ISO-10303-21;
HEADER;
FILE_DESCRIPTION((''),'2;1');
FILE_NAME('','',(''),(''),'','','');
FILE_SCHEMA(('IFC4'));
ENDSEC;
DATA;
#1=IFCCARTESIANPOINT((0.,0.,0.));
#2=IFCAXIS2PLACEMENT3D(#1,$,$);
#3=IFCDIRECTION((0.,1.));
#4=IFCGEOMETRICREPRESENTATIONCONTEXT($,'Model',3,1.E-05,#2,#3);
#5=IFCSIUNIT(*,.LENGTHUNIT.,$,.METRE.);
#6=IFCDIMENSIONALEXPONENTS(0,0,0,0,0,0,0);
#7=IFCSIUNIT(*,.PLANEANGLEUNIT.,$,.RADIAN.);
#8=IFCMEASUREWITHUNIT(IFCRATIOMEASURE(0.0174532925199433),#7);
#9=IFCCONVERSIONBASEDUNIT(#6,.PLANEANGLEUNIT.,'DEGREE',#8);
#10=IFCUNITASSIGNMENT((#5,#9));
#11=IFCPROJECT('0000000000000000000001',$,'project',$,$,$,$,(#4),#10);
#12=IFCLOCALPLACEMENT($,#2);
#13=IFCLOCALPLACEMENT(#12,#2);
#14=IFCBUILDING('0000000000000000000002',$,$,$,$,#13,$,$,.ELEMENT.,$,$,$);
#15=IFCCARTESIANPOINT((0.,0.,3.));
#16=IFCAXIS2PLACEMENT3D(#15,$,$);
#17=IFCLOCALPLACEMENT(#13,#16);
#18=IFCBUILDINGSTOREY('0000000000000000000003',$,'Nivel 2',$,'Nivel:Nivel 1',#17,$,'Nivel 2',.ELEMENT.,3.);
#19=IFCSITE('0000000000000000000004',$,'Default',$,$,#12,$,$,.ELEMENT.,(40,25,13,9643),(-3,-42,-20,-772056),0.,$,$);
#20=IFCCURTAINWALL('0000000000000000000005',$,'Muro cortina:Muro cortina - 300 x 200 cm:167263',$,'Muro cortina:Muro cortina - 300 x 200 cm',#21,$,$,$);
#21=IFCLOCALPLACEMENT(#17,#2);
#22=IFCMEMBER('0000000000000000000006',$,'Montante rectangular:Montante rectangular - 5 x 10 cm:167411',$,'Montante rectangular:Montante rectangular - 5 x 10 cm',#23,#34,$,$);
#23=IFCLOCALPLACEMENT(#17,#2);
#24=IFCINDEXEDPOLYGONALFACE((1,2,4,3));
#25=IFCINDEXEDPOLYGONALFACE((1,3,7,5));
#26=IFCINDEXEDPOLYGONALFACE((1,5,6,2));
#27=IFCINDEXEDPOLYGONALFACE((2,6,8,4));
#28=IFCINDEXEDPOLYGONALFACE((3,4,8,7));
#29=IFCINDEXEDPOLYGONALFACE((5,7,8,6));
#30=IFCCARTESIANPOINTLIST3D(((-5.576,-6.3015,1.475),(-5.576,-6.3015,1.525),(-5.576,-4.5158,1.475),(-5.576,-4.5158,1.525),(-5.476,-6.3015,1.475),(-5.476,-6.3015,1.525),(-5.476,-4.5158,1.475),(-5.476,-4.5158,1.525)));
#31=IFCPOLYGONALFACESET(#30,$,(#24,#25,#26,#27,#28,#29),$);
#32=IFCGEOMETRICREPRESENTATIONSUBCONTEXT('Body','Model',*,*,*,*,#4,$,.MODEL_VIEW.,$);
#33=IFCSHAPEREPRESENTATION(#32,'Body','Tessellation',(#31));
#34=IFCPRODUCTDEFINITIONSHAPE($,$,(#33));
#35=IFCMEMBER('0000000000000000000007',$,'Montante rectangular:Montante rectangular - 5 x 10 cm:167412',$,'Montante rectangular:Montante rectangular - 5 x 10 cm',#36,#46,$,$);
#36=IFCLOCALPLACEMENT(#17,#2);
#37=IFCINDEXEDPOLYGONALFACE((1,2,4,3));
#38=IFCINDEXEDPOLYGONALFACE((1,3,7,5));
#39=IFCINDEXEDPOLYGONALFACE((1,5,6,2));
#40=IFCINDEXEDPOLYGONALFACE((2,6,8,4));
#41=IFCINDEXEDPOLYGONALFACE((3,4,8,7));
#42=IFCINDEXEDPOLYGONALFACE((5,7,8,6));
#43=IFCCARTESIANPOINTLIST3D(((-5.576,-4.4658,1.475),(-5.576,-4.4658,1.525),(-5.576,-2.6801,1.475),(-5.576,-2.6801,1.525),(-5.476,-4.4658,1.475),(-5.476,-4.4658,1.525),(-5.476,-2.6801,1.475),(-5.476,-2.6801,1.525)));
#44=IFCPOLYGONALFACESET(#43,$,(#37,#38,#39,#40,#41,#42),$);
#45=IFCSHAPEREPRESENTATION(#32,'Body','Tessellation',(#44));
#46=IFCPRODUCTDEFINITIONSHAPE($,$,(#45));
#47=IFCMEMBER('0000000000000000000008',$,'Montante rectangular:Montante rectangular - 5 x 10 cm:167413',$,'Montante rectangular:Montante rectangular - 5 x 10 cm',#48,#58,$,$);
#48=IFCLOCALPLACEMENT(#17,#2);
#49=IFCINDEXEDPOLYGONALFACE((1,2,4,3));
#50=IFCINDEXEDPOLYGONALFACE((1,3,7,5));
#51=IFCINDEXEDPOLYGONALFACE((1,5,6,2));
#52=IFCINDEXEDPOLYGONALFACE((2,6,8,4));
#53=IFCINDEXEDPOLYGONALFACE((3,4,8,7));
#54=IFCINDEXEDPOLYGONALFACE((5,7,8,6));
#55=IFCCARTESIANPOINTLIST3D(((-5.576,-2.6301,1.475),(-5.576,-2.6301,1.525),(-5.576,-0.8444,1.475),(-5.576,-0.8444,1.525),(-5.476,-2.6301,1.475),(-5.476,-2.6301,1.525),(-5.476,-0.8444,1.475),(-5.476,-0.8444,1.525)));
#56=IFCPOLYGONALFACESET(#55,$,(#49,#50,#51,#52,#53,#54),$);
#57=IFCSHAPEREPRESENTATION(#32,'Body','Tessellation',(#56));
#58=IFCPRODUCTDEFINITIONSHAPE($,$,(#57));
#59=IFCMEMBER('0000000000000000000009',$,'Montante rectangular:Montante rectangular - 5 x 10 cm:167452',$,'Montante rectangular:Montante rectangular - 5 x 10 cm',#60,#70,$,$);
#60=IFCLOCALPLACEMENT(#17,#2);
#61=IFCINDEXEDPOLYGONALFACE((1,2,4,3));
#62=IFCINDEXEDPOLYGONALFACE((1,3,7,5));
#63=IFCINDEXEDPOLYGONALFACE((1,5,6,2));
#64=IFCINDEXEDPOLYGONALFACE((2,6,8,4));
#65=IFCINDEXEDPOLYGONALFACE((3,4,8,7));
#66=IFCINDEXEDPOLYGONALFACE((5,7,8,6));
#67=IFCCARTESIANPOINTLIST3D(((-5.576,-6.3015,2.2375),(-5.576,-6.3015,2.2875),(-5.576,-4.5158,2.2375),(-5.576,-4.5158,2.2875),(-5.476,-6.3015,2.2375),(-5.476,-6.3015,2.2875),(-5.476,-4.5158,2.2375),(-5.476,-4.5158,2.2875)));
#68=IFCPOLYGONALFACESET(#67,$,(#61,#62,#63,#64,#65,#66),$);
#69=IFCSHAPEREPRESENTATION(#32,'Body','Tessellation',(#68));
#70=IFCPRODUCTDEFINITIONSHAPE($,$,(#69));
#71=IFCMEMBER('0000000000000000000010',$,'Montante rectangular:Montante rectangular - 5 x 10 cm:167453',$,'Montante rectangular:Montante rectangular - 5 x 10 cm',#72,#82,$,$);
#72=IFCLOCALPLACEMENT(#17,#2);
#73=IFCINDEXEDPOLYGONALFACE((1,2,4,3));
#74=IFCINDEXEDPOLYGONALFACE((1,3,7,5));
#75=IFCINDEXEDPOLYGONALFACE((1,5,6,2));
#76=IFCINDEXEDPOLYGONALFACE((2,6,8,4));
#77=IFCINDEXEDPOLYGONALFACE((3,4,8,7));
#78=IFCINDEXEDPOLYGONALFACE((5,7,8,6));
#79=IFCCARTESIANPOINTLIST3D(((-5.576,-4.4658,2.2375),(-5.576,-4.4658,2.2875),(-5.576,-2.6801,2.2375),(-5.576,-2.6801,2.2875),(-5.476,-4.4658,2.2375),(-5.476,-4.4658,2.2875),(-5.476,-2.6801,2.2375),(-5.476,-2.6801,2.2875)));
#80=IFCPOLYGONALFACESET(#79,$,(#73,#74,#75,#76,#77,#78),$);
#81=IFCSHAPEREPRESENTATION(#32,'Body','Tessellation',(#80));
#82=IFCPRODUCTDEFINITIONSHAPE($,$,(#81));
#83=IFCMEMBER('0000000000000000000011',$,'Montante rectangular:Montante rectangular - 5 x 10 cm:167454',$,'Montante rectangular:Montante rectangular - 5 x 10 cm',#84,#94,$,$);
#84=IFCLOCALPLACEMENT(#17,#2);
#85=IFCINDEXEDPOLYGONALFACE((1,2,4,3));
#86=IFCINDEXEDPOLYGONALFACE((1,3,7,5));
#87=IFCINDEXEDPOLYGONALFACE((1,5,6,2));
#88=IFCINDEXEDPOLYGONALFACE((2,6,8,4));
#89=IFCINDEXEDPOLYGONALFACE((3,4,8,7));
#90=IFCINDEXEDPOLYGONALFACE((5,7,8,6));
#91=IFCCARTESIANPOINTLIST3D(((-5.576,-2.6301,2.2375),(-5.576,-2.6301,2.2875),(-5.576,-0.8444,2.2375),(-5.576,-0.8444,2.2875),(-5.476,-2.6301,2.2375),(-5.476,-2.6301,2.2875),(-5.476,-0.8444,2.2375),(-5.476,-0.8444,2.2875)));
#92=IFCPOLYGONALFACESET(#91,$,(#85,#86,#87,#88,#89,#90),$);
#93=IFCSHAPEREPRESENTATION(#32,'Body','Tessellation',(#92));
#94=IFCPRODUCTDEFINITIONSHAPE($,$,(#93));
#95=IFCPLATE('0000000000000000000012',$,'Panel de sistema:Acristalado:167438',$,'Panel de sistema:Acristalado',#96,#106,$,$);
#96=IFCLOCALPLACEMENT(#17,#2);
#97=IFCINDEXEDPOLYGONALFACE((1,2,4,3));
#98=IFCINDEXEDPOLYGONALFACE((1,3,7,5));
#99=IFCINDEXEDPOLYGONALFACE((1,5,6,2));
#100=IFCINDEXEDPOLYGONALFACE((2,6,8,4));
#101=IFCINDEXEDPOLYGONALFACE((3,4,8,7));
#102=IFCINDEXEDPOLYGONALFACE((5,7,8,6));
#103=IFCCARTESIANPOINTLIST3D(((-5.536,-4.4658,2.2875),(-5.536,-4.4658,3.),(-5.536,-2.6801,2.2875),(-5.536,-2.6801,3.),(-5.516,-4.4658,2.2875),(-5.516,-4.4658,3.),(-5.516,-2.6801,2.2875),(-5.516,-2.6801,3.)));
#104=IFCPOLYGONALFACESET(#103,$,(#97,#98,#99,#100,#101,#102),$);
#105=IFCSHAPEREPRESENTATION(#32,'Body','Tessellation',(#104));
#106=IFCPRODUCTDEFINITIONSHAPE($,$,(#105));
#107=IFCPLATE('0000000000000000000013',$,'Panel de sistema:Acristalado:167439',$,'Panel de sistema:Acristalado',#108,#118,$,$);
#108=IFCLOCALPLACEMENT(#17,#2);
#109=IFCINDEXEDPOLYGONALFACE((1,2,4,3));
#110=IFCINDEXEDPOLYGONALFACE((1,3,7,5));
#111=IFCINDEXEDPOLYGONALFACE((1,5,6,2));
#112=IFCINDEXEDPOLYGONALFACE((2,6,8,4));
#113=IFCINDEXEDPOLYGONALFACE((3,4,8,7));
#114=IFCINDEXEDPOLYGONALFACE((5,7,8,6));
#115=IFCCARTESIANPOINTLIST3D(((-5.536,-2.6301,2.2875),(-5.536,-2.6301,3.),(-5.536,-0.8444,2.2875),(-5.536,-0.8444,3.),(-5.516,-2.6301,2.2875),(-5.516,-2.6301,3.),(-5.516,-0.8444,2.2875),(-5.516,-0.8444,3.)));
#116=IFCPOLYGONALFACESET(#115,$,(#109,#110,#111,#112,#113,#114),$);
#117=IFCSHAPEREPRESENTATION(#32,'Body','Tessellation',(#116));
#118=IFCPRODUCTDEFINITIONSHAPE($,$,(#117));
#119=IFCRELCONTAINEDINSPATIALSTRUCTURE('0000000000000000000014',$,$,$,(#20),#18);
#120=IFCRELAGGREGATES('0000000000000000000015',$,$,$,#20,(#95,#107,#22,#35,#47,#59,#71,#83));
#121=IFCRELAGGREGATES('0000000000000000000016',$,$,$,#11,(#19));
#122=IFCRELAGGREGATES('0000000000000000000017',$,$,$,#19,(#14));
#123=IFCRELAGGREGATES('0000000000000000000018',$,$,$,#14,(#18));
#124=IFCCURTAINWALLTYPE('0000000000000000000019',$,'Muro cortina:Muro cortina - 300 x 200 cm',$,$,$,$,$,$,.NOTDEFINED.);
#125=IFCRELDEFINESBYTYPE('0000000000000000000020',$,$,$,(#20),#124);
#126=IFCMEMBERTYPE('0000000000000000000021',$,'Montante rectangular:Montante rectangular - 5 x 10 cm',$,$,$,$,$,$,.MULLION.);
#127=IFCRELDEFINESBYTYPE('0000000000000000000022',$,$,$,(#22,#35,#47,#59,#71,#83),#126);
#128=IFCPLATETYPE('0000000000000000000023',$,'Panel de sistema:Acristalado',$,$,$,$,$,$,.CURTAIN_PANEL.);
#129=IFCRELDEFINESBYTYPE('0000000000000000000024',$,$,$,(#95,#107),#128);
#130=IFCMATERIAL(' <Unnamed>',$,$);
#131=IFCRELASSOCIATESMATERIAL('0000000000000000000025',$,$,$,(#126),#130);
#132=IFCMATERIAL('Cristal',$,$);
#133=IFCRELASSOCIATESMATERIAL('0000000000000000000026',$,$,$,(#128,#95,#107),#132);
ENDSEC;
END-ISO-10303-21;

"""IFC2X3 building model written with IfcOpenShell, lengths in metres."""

from ifc_helpers import new_model, entity, si_unit, converted_unit, direction, frame, origin, origin_2d_with_axis, place, context, subcontext, project, spatial, rectangle, extrude, source, transform, mapped, material, type_object, type_shapes, element, aggregate, save


model = new_model("IFC2X3")

# Units and contexts
model_context = context("Model", 3, precision=1e-05, world=origin(), true_north=direction((0.0, 1.0)))
body_context = subcontext(model_context, "Body", "Model", "MODEL_VIEW")
ifc_project = project(units=[si_unit("LENGTHUNIT", "METRE"), converted_unit("PLANEANGLEUNIT", "DEGREE", entity("IfcRatioMeasure", 0.0174532925199433), si_unit("PLANEANGLEUNIT", "RADIAN"), dimensions=[0, 0, 0, 0, 0, 0, 0])], contexts=[model_context])

# Site, building, storey
site_placement = place(None, origin())
site = spatial("IfcSite", under=ifc_project, at=site_placement, Name="Default", CompositionType="ELEMENT", RefLatitude=(40, 25, 13, 9643), RefLongitude=(-3, -42, -20, -772056), RefElevation=0.0)
building_placement = place(site_placement, origin())
building = spatial("IfcBuilding", under=site, at=building_placement, CompositionType="ELEMENT")
storey_placement = place(building_placement, frame((0.0, 0.0, 3.0)))
storey = spatial("IfcBuildingStorey", under=building, at=storey_placement, Name="Nivel 2", ObjectType="Nivel:Nivel 1", LongName="Nivel 2", CompositionType="ELEMENT", Elevation=3.0)

# Curtain wall, members, plates
curtain_wall_type = type_object("IfcCurtainWallType", Name="Muro cortina:Muro cortina - 300 x 200 cm", PredefinedType="NOTDEFINED")
curtain_wall_placement = place(storey_placement, frame((0.0, 0.0, -3.0)))
curtain_wall = element("IfcCurtainWall", 1, at=curtain_wall_placement, inside=storey, type_object=curtain_wall_type, Name="Muro cortina:Muro cortina - 300 x 200 cm:167263", ObjectType="Muro cortina:Muro cortina - 300 x 200 cm")
ifc_material_1 = material(Name=" <Unnamed>")
member_type_1 = type_object("IfcMemberType", Name="Montante rectangular:Montante rectangular - 5 x 10 cm", PredefinedType="MULLION", material=ifc_material_1)
shared_shape_1 = source(origin(), body_context, "Body", "SweptSolid", [
    extrude(rectangle(XDim=0.1, YDim=0.05, at=origin_2d_with_axis()), frame((0.0, 0.0, -1.7857), z_axis=(0.0, 0.0, 1.0), x_axis=(0.0, -1.0, 0.0)), (0.0, 0.0, 1.0), 1.7857),
])
type_shapes(member_type_1, [shared_shape_1])
member_1_placement = place(storey_placement, frame((-5.526, -4.5158, 1.5), z_axis=(0.0, 1.0, 0.0), x_axis=(0.0, 0.0, 1.0)))
member_1 = element("IfcMember", 2, at=member_1_placement, type_object=member_type_1, Name="Montante rectangular:Montante rectangular - 5 x 10 cm:167411", ObjectType="Montante rectangular:Montante rectangular - 5 x 10 cm", context=body_context, shape_type="MappedRepresentation", body=[
    mapped(shared_shape_1, transform((0.0, 0.0, 0.0), scale=1.0)),
])
member_2_placement = place(storey_placement, frame((-5.526, -2.6801, 1.5), z_axis=(0.0, 1.0, 0.0), x_axis=(0.0, 0.0, 1.0)))
member_2 = element("IfcMember", 3, at=member_2_placement, type_object=member_type_1, Name="Montante rectangular:Montante rectangular - 5 x 10 cm:167412", ObjectType="Montante rectangular:Montante rectangular - 5 x 10 cm", context=body_context, shape_type="MappedRepresentation", body=[
    mapped(shared_shape_1, transform((0.0, 0.0, 0.0), scale=1.0)),
])
member_3_placement = place(storey_placement, frame((-5.526, -0.8444, 1.5), z_axis=(0.0, 1.0, 0.0), x_axis=(0.0, 0.0, 1.0)))
member_3 = element("IfcMember", 4, at=member_3_placement, type_object=member_type_1, Name="Montante rectangular:Montante rectangular - 5 x 10 cm:167413", ObjectType="Montante rectangular:Montante rectangular - 5 x 10 cm", context=body_context, shape_type="MappedRepresentation", body=[
    mapped(shared_shape_1, transform((0.0, 0.0, 0.0), scale=1.0)),
])
member_4_placement = place(storey_placement, frame((-5.526, -4.5158, 2.2625), z_axis=(0.0, 1.0, 0.0), x_axis=(0.0, 0.0, 1.0)))
member_4 = element("IfcMember", 5, at=member_4_placement, type_object=member_type_1, Name="Montante rectangular:Montante rectangular - 5 x 10 cm:167452", ObjectType="Montante rectangular:Montante rectangular - 5 x 10 cm", context=body_context, shape_type="MappedRepresentation", body=[
    mapped(shared_shape_1, transform((0.0, 0.0, 0.0), scale=1.0)),
])
member_5_placement = place(storey_placement, frame((-5.526, -2.6801, 2.2625), z_axis=(0.0, 1.0, 0.0), x_axis=(0.0, 0.0, 1.0)))
member_5 = element("IfcMember", 6, at=member_5_placement, type_object=member_type_1, Name="Montante rectangular:Montante rectangular - 5 x 10 cm:167453", ObjectType="Montante rectangular:Montante rectangular - 5 x 10 cm", context=body_context, shape_type="MappedRepresentation", body=[
    mapped(shared_shape_1, transform((0.0, 0.0, 0.0), scale=1.0)),
])
member_6_placement = place(storey_placement, frame((-5.526, -0.8444, 2.2625), z_axis=(0.0, 1.0, 0.0), x_axis=(0.0, 0.0, 1.0)))
member_6 = element("IfcMember", 7, at=member_6_placement, type_object=member_type_1, Name="Montante rectangular:Montante rectangular - 5 x 10 cm:167454", ObjectType="Montante rectangular:Montante rectangular - 5 x 10 cm", context=body_context, shape_type="MappedRepresentation", body=[
    mapped(shared_shape_1, transform((0.0, 0.0, 0.0), scale=1.0)),
])
ifc_material_2 = material(Name="Cristal")
plate_type = type_object("IfcPlateType", Name="Panel de sistema:Acristalado", PredefinedType="CURTAIN_PANEL", material=ifc_material_2)
shared_shape_2 = source(origin(), body_context, "Body", "SweptSolid", [
    extrude(rectangle(XDim=0.02, YDim=1.7857, at=origin_2d_with_axis()), frame((0.0, 0.0, 0.0), z_axis=(0.0, 0.0, 1.0), x_axis=(0.0, 1.0, 0.0)), (0.0, 0.0, 1.0), 0.7125),
])
type_shapes(plate_type, [shared_shape_2])
plate_1_placement = place(curtain_wall_placement, frame((-5.526, -3.573, 5.2875), z_axis=(0.0, 0.0, 1.0), x_axis=(0.0, 1.0, 0.0)))
plate_1 = element("IfcPlate", 8, at=plate_1_placement, type_object=plate_type, material=ifc_material_2, Name="Panel de sistema:Acristalado:167438", ObjectType="Panel de sistema:Acristalado", context=body_context, shape_type="MappedRepresentation", body=[
    mapped(shared_shape_2, transform((0.0, 0.0, 0.0), scale=1.0)),
])
plate_2_placement = place(curtain_wall_placement, frame((-5.526, -1.7373, 5.2875), z_axis=(0.0, 0.0, 1.0), x_axis=(0.0, 1.0, 0.0)))
plate_2 = element("IfcPlate", 9, at=plate_2_placement, type_object=plate_type, material=ifc_material_2, Name="Panel de sistema:Acristalado:167439", ObjectType="Panel de sistema:Acristalado", context=body_context, shape_type="MappedRepresentation", body=[
    mapped(shared_shape_2, transform((0.0, 0.0, 0.0), scale=1.0)),
])
aggregate(curtain_wall, [plate_1, plate_2, member_1, member_2, member_3, member_4, member_5, member_6])

save(model, "model.ifc")
